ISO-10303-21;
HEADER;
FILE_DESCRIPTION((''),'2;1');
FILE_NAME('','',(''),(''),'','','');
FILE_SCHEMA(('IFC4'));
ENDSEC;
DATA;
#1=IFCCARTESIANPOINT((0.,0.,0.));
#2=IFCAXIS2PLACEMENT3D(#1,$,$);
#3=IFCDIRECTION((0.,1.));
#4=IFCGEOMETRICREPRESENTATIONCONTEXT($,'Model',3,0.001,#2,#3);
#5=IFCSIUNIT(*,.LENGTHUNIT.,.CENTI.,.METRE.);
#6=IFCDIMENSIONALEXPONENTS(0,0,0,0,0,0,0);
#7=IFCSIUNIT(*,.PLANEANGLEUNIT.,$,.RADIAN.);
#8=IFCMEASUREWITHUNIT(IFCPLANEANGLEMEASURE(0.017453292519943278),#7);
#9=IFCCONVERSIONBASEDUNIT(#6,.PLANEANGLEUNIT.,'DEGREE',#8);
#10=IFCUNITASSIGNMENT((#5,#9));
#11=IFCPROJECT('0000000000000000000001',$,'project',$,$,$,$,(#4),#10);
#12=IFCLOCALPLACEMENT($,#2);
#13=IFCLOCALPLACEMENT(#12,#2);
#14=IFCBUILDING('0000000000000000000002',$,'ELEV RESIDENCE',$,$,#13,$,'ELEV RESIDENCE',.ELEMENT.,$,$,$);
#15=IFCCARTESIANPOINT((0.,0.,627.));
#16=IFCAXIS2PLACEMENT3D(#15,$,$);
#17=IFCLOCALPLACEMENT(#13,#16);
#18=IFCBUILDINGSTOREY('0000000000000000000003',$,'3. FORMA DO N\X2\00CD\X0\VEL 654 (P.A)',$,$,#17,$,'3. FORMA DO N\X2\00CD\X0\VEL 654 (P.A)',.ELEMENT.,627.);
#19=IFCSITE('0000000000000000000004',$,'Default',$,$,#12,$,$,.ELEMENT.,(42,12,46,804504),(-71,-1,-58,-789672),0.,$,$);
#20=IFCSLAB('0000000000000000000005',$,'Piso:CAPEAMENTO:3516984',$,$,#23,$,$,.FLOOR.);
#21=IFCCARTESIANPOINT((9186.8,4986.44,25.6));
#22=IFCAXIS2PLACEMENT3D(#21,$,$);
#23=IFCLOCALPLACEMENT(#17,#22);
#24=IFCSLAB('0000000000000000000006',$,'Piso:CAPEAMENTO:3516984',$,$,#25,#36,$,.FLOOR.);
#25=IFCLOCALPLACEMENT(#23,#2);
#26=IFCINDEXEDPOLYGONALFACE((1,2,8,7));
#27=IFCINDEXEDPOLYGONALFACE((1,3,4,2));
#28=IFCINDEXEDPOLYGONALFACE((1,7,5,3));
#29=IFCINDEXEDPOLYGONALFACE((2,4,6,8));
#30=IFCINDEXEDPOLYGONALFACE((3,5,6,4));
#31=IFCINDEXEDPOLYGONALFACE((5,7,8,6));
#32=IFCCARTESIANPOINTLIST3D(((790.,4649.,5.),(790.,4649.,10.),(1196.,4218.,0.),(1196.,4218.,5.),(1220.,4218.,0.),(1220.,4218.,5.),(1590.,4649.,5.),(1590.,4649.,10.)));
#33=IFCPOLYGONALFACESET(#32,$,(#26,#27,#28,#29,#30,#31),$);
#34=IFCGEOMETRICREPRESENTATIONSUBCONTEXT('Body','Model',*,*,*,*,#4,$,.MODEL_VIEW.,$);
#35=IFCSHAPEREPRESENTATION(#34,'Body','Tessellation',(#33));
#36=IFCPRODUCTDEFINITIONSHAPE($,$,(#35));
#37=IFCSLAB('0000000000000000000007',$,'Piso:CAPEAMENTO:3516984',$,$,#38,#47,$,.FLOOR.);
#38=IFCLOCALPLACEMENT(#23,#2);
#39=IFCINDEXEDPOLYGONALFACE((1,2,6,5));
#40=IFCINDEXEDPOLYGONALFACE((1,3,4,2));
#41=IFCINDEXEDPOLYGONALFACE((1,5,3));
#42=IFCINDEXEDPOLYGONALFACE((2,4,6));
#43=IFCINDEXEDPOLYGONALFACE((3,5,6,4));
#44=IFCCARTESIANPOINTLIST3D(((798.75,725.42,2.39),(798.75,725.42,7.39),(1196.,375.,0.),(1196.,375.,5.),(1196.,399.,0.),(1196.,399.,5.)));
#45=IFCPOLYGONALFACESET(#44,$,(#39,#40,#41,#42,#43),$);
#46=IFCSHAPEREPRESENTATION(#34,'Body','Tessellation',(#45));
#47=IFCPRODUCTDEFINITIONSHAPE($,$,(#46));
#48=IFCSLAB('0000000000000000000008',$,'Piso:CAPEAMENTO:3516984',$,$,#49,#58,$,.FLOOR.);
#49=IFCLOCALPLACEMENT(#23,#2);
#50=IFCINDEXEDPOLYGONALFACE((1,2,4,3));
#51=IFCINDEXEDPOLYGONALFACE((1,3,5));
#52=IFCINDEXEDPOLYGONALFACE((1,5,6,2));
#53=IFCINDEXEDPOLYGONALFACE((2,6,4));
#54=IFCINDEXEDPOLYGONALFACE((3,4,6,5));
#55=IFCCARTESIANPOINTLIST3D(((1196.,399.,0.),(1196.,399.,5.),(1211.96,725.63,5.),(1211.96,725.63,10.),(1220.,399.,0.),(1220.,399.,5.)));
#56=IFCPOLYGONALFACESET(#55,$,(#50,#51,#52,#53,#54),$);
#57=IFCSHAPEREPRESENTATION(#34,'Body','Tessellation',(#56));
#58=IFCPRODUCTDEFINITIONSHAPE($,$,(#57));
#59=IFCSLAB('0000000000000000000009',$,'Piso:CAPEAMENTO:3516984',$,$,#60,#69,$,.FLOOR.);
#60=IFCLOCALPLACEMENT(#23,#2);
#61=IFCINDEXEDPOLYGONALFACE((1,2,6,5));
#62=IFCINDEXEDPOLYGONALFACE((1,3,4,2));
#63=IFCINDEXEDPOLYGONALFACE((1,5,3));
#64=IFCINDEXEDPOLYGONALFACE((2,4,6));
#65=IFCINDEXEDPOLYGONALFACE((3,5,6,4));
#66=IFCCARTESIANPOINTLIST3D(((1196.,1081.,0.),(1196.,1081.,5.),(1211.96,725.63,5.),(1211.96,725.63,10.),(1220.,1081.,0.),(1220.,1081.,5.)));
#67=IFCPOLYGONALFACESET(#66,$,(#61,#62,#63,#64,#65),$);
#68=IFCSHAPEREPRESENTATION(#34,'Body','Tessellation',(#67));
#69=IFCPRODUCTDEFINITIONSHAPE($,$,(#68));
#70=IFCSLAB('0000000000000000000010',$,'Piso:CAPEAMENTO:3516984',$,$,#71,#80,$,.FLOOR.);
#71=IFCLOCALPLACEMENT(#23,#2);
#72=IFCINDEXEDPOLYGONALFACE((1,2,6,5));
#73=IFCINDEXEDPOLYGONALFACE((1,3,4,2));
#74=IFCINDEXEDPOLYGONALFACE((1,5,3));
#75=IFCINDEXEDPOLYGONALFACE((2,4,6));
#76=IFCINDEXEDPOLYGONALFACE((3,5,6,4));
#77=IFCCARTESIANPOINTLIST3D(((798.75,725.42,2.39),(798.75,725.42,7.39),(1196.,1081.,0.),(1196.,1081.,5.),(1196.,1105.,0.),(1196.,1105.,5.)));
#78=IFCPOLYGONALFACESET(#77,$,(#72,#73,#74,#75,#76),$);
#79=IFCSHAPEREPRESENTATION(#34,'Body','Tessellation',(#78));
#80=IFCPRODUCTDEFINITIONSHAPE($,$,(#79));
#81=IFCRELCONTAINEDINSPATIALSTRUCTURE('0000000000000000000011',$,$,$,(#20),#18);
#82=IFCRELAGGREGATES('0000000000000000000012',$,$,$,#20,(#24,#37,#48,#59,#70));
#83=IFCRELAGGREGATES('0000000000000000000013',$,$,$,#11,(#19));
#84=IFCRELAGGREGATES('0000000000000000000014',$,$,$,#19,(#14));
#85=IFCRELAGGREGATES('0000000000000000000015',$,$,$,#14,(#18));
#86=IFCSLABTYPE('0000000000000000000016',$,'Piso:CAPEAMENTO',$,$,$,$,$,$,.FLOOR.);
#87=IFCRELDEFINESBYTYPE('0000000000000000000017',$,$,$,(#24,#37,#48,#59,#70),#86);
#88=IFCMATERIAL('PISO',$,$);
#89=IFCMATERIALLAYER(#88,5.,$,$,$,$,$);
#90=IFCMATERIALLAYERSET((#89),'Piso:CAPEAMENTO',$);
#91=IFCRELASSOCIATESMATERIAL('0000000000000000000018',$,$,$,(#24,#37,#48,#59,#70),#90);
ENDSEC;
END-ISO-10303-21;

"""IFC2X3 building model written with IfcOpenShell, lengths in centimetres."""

from ifc_helpers import new_model, entity, si_unit, converted_unit, direction, frame, origin, place, context, subcontext, project, spatial, polyline, outline, extrude, material, layer, layer_set, type_object, element, aggregate, save


model = new_model("IFC2X3")

# Units and contexts
model_context = context("Model", 3, precision=0.001, world=origin(), true_north=direction((0.0, 1.0)))
body_context = subcontext(model_context, "Body", "Model", "MODEL_VIEW")
ifc_project = project(units=[si_unit("LENGTHUNIT", "METRE", prefix="CENTI"), converted_unit("PLANEANGLEUNIT", "DEGREE", entity("IfcPlaneAngleMeasure", 0.017453292519943278), si_unit("PLANEANGLEUNIT", "RADIAN"), dimensions=[0, 0, 0, 0, 0, 0, 0])], contexts=[model_context])

# Site, building, storey
site_placement = place(None, origin())
site = spatial("IfcSite", under=ifc_project, at=site_placement, Name="Default", CompositionType="ELEMENT", RefLatitude=(42, 12, 46, 804504), RefLongitude=(-71, -1, -58, -789672), RefElevation=0.0)
building_placement = place(site_placement, origin())
building = spatial("IfcBuilding", under=site, at=building_placement, Name="ELEV RESIDENCE", LongName="ELEV RESIDENCE", CompositionType="ELEMENT")
storey_placement = place(building_placement, frame((0.0, 0.0, 627.0)))
storey = spatial("IfcBuildingStorey", under=building, at=storey_placement, Name="3. FORMA DO NÍVEL 654 (P.A)", LongName="3. FORMA DO NÍVEL 654 (P.A)", CompositionType="ELEMENT", Elevation=627.0)

# Slabs
slab_1_placement = place(storey_placement, frame((9186.8, 4986.44, 25.6)))
slab_1 = element("IfcSlab", 1, at=slab_1_placement, inside=storey, Name="Piso:CAPEAMENTO:3516984", PredefinedType="FLOOR")
ifc_material = material(Name="PISO")
ifc_layer = layer(ifc_material, 5.0)
ifc_layer_set = layer_set([ifc_layer], Name="Piso:CAPEAMENTO")
slab_type = type_object("IfcSlabType", Name="Piso:CAPEAMENTO", PredefinedType="FLOOR")
slab_2_placement = place(slab_1_placement, origin())
slab_2 = element("IfcSlab", 2, at=slab_2_placement, type_object=slab_type, material=ifc_layer_set, Name="Piso:CAPEAMENTO:3516984", PredefinedType="FLOOR", context=body_context, shape_type="SweptSolid", body=[
    extrude(outline(polyline([(400.0, 215.51), (-400.0, 215.51), (6.0, -215.51), (30.0, -215.51), (400.0, 215.51)])), frame((1190.0, 4433.5, 7.5), z_axis=(0.0, -0.0116, 0.999933), x_axis=(1.0, 0.0, 0.0)), (0.0, -0.0116, -0.999933), 5.0),
])
slab_3_placement = place(slab_1_placement, origin())
slab_3 = element("IfcSlab", 3, at=slab_3_placement, type_object=slab_type, material=ifc_layer_set, Name="Piso:CAPEAMENTO:3516984", PredefinedType="FLOOR", context=body_context, shape_type="SweptSolid", body=[
    extrude(outline(polyline([(198.63, -175.21), (198.63, -151.21), (-198.63, 175.21), (198.63, -175.21)])), frame((997.38, 550.21, 6.2), z_axis=(0.006024, 0.0, 0.999982), x_axis=(0.999982, 0.0, -0.006024)), (0.006024, 0.0, -0.999982), 5.0),
])
slab_4_placement = place(slab_1_placement, origin())
slab_4 = element("IfcSlab", 4, at=slab_4_placement, type_object=slab_type, material=ifc_layer_set, Name="Piso:CAPEAMENTO:3516984", PredefinedType="FLOOR", context=body_context, shape_type="SweptSolid", body=[
    extrude(outline(polyline([(-12.0, -163.34), (12.0, -163.34), (3.96, 163.34), (-12.0, -163.34)])), frame((1208.0, 562.31, 7.5), z_axis=(0.0, -0.015306, 0.999883), x_axis=(1.0, 0.0, 0.0)), (0.0, -0.015306, -0.999883), 5.0),
])
slab_5_placement = place(slab_1_placement, origin())
slab_5 = element("IfcSlab", 5, at=slab_5_placement, type_object=slab_type, material=ifc_layer_set, Name="Piso:CAPEAMENTO:3516984", PredefinedType="FLOOR", context=body_context, shape_type="SweptSolid", body=[
    extrude(outline(polyline([(12.0, 177.7), (-12.0, 177.7), (3.96, -177.7), (12.0, 177.7)])), frame((1208.0, 903.31, 7.5), z_axis=(0.0, 0.014069, 0.999901), x_axis=(1.0, 0.0, 0.0)), (0.0, 0.014069, -0.999901), 5.0),
])
slab_6_placement = place(slab_1_placement, origin())
slab_6 = element("IfcSlab", 6, at=slab_6_placement, type_object=slab_type, material=ifc_layer_set, Name="Piso:CAPEAMENTO:3516984", PredefinedType="FLOOR", context=body_context, shape_type="SweptSolid", body=[
    extrude(outline(polyline([(198.63, 165.79), (198.63, 189.79), (-198.63, -189.79), (198.63, 165.79)])), frame((997.38, 915.21, 6.2), z_axis=(0.006024, 0.0, 0.999982), x_axis=(0.999982, 0.0, -0.006024)), (0.006024, 0.0, -0.999982), 5.0),
])
aggregate(slab_1, [slab_2, slab_3, slab_4, slab_5, slab_6])

save(model, "model.ifc")
